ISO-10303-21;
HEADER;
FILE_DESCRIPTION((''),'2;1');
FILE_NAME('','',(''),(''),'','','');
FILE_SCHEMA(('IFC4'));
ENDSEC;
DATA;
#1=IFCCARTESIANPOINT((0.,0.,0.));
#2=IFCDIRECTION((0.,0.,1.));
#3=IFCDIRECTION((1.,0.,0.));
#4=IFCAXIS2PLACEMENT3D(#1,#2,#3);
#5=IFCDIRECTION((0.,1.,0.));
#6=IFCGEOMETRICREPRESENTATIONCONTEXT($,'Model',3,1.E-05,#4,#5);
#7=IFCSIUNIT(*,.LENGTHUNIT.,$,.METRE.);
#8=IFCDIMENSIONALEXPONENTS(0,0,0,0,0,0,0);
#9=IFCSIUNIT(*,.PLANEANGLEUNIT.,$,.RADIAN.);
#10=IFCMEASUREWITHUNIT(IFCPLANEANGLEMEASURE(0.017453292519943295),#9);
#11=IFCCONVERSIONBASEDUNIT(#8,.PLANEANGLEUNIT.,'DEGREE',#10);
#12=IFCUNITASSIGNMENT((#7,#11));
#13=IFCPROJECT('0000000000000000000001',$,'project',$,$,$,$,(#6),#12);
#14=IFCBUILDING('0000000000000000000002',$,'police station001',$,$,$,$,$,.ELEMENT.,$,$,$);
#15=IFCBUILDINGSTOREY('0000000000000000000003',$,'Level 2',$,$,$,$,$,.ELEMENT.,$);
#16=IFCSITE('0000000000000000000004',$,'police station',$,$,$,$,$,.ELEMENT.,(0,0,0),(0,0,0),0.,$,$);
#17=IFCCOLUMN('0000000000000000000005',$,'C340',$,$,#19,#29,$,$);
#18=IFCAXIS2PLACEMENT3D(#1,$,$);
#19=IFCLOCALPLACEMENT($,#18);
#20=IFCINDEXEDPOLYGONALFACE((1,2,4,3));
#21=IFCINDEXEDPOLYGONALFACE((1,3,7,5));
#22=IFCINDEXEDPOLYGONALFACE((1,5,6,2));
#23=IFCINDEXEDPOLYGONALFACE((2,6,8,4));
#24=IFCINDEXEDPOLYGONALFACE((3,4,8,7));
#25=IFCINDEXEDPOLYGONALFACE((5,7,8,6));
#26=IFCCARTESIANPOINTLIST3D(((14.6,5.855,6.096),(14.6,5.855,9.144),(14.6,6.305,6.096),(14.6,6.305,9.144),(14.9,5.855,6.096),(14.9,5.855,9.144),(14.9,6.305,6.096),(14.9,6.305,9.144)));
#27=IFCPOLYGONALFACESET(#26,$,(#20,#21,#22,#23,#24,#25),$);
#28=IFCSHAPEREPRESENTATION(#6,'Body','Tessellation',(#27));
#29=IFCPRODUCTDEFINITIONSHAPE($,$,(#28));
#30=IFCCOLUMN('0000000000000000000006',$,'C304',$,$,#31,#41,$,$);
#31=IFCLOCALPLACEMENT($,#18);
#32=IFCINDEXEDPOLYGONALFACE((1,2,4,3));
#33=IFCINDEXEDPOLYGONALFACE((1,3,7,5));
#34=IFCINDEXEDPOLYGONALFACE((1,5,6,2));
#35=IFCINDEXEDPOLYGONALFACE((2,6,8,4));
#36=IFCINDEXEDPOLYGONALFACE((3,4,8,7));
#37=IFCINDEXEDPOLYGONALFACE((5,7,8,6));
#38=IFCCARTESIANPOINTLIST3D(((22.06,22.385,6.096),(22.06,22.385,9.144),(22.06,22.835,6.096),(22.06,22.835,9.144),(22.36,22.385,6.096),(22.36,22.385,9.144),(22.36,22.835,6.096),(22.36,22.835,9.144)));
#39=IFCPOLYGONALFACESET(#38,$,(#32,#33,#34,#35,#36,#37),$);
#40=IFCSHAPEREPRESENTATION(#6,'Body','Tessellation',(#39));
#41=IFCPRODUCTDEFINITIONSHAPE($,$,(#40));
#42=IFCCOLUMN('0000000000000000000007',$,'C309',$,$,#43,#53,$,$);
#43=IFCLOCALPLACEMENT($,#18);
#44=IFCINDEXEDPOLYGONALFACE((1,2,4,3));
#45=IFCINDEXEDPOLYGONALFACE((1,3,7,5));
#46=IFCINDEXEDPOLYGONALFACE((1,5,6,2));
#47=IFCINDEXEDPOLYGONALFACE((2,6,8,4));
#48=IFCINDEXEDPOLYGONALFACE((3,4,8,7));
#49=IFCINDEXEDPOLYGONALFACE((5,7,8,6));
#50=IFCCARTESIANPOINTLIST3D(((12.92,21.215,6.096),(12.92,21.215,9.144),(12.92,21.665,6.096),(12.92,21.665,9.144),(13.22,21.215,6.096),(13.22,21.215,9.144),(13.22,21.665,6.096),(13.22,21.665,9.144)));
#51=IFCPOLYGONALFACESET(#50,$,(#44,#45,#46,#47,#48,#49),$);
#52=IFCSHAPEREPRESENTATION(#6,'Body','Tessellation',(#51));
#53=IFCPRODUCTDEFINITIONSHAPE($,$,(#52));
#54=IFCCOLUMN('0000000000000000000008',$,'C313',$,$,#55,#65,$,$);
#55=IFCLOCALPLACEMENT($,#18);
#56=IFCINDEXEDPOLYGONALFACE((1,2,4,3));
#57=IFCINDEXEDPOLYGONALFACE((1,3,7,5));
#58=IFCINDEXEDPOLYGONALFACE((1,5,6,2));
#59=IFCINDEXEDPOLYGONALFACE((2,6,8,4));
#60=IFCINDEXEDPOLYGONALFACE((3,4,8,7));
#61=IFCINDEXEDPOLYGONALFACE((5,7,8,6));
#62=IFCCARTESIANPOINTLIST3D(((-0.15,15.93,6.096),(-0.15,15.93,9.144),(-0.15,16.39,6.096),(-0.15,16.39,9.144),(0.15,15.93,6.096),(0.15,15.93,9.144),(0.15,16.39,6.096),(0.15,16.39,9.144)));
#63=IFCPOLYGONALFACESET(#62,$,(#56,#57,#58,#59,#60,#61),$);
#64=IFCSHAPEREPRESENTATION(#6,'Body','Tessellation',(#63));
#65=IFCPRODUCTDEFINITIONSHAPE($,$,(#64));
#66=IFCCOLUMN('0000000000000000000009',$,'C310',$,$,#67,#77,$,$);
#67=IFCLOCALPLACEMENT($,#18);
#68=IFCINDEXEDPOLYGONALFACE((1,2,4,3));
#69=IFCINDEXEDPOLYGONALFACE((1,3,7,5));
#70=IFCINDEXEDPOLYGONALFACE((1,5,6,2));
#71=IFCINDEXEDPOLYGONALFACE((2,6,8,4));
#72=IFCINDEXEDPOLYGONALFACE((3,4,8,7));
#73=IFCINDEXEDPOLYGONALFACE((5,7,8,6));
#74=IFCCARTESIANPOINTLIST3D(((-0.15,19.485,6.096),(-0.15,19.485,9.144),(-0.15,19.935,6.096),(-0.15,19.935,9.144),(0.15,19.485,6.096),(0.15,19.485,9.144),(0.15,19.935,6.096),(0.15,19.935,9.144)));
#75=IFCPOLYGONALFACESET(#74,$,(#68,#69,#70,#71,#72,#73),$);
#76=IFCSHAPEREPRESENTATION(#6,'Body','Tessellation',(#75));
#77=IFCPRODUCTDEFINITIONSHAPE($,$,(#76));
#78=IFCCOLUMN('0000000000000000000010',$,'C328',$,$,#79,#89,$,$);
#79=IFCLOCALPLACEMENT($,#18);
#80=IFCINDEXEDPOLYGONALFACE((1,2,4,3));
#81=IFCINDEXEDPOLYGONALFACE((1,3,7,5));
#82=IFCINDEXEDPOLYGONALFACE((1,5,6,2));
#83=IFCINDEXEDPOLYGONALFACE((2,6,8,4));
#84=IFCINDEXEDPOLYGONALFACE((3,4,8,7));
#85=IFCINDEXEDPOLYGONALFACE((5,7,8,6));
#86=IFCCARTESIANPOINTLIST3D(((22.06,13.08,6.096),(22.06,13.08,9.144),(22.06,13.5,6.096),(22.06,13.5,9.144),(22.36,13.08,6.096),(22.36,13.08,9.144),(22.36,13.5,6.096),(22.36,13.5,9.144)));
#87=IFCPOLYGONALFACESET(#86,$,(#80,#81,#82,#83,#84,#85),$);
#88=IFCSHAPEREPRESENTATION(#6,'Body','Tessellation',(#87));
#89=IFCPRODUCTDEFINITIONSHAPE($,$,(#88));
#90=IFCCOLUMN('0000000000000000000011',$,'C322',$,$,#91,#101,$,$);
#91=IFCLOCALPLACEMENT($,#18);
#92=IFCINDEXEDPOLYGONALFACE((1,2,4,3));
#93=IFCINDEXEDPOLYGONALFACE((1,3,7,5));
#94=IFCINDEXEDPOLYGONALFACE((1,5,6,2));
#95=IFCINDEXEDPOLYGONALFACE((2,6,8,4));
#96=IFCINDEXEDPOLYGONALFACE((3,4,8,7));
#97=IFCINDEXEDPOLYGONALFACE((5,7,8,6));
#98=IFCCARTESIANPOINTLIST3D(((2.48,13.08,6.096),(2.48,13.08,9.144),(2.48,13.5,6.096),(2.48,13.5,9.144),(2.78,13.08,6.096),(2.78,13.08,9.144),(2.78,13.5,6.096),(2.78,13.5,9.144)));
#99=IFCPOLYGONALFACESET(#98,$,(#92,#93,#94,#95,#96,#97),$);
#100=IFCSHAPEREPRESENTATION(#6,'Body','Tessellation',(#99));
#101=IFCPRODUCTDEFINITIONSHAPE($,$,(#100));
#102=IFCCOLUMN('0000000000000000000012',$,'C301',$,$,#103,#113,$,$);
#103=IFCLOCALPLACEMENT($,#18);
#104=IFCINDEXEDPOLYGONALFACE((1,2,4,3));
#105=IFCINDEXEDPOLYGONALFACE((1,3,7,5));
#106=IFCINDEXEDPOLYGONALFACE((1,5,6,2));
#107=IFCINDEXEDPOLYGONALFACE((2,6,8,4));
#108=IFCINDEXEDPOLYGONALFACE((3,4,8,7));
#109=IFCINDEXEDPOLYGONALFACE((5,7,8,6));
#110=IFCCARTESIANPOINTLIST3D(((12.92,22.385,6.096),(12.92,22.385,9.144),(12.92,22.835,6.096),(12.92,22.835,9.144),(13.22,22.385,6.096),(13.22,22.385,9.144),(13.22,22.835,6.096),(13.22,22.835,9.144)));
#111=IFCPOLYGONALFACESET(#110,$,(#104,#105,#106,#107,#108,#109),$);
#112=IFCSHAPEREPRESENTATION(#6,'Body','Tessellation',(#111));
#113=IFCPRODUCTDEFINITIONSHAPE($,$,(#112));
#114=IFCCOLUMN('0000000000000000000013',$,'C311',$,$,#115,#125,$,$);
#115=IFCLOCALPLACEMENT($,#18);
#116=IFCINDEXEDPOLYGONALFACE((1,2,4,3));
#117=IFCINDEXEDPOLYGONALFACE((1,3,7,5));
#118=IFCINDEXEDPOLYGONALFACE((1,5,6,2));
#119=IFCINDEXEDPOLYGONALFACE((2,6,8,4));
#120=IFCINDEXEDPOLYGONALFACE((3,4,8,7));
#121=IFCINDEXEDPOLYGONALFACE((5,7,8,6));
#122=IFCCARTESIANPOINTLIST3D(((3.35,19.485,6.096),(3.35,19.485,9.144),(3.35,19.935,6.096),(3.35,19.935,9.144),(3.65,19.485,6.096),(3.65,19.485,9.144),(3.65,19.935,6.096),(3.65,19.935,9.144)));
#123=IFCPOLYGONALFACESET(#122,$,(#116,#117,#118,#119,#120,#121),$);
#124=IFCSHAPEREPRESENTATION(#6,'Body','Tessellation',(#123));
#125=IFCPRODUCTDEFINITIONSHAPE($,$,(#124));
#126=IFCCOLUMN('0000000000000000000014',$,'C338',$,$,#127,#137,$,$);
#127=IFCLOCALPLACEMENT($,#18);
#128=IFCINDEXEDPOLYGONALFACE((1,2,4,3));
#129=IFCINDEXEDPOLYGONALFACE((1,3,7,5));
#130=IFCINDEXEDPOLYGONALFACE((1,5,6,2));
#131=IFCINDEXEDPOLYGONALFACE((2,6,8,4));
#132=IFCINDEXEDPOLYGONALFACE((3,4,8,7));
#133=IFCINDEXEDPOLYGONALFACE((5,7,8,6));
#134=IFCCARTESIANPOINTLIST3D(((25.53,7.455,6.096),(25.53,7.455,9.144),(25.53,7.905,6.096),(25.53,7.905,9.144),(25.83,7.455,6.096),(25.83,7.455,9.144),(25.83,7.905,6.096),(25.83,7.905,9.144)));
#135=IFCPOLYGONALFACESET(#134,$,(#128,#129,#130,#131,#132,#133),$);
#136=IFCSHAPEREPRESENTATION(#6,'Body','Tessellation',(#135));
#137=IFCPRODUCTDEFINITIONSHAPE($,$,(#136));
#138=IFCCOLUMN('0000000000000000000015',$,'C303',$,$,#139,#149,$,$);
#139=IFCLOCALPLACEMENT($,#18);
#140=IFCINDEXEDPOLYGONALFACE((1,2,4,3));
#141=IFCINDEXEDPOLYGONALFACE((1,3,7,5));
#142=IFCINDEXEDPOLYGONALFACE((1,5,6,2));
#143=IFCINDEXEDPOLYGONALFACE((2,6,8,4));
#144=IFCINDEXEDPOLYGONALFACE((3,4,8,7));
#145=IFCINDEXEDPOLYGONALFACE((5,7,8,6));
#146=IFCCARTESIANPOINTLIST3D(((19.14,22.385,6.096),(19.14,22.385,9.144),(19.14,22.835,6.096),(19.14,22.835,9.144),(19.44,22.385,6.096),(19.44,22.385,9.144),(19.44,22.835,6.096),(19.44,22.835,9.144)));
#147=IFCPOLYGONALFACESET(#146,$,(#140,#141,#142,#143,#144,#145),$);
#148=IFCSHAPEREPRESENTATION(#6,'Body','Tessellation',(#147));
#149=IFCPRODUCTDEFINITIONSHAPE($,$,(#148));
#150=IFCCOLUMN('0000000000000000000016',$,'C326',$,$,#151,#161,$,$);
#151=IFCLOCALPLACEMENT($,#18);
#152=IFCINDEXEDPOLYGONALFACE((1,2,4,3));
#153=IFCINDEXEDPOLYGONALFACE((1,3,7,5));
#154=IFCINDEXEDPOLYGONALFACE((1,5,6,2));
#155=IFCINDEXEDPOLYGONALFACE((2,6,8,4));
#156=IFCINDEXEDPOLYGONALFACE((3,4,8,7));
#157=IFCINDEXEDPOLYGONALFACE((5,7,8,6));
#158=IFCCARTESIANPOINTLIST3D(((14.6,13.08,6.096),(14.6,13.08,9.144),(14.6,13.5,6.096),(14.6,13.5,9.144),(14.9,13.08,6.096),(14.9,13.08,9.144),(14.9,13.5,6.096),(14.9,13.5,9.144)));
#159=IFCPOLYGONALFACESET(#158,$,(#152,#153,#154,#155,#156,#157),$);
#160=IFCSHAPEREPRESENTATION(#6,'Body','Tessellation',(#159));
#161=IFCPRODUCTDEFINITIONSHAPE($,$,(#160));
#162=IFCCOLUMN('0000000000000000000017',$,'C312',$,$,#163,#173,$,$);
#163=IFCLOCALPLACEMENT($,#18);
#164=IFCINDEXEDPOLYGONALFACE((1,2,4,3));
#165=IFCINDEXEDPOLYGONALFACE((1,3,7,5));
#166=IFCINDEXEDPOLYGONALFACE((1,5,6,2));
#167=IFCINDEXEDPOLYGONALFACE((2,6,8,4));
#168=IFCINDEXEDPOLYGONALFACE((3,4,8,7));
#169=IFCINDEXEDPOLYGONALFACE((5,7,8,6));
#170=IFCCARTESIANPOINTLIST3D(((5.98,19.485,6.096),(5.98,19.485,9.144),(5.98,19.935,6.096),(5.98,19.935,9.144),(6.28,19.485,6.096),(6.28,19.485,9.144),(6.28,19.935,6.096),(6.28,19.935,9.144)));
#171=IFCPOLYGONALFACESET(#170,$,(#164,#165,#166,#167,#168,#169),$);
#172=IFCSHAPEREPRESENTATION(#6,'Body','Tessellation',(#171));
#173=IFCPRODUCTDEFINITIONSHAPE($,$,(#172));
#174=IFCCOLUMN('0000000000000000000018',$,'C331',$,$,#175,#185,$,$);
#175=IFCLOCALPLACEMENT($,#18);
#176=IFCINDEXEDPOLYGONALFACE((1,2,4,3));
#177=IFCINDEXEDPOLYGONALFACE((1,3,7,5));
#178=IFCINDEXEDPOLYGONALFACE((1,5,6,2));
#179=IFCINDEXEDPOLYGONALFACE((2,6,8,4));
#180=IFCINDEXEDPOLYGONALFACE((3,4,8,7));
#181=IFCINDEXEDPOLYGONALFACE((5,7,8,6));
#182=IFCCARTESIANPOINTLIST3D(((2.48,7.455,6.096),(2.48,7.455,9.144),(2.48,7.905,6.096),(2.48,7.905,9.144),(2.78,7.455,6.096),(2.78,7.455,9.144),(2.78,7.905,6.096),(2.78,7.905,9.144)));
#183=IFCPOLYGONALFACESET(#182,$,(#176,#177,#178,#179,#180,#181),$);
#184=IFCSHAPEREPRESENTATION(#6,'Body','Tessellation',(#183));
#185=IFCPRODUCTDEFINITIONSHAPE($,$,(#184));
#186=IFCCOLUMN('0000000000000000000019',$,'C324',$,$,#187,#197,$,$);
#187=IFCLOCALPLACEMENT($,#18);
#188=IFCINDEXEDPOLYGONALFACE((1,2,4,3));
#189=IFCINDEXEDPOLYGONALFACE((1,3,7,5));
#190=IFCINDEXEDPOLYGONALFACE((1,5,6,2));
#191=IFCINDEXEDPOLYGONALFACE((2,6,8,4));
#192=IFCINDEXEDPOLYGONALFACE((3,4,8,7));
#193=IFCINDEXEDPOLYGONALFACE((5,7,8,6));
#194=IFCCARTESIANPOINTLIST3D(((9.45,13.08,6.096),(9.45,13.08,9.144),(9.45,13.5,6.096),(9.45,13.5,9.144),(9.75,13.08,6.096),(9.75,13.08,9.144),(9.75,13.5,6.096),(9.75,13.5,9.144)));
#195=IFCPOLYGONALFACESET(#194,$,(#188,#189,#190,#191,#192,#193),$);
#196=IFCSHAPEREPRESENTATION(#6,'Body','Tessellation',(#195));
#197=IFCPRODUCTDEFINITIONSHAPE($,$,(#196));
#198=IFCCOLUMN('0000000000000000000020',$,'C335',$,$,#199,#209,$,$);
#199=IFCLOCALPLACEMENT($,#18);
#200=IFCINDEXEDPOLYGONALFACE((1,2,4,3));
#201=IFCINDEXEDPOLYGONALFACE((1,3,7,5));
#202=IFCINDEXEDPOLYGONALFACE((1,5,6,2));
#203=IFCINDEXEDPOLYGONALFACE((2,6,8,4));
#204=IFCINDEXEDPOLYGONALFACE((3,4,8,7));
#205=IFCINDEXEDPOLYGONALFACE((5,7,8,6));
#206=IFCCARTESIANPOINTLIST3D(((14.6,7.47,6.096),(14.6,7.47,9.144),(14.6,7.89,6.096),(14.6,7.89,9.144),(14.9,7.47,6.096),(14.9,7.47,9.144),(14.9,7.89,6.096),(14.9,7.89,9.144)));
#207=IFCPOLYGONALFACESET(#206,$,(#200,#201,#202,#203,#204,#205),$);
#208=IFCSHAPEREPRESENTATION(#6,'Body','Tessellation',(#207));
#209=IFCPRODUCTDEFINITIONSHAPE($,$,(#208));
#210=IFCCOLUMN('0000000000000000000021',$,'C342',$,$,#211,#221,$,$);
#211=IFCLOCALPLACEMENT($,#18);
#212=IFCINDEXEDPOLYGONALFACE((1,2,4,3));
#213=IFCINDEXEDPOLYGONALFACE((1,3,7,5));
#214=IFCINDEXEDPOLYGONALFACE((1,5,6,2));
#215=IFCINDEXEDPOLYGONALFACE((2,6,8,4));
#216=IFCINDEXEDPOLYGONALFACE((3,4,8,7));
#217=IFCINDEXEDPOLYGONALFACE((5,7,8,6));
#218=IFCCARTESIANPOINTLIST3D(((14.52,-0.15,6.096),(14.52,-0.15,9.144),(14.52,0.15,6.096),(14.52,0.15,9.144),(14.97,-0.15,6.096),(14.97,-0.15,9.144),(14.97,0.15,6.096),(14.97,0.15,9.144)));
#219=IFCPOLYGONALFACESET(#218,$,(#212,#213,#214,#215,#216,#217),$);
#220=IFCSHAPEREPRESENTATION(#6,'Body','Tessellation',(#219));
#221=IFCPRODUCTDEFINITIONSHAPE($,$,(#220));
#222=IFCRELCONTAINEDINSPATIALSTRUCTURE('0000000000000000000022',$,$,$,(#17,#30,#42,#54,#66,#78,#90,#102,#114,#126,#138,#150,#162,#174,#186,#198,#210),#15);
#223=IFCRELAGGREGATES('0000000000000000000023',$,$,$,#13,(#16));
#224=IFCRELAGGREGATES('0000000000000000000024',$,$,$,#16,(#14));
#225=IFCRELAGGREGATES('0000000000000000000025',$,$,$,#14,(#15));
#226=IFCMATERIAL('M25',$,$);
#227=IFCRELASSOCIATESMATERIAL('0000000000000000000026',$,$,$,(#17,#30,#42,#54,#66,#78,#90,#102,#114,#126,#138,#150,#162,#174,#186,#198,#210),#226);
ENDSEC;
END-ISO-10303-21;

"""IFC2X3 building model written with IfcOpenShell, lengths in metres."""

from ifc_helpers import new_model, entity, si_unit, converted_unit, direction, frame, frame_2d, origin_with_axes, place, context, project, spatial, rectangle, extrude, material, element, save


model = new_model("IFC2X3")

# Units and contexts
model_context = context("Model", 3, precision=1e-05, world=origin_with_axes(), true_north=direction((0.0, 1.0, 0.0)))
ifc_project = project(units=[si_unit("LENGTHUNIT", "METRE"), converted_unit("PLANEANGLEUNIT", "DEGREE", entity("IfcPlaneAngleMeasure", 0.017453292519943295), si_unit("PLANEANGLEUNIT", "RADIAN"), dimensions=[0, 0, 0, 0, 0, 0, 0])], contexts=[model_context])

# Site, building, storey
site = spatial("IfcSite", under=ifc_project, Name="police station", CompositionType="ELEMENT", RefLatitude=(0, 0, 0), RefLongitude=(0, 0, 0), RefElevation=0.0)
building = spatial("IfcBuilding", under=site, Name="police station001", CompositionType="ELEMENT")
storey = spatial("IfcBuildingStorey", under=building, Name="Level 2", CompositionType="ELEMENT")

# Columns
ifc_material = material(Name="M25")
placement = place(None, origin_with_axes())
element("IfcColumn", 1, at=placement, inside=storey, material=ifc_material, Name="C340", context=model_context, shape_type="SweptSolid", body=[
    extrude(rectangle(XDim=0.3, YDim=0.45, at=frame_2d((0.0, 0.0), x_axis=(1.0, 0.0, 0.0))), frame((14.75, 6.08, 6.096), z_axis=(0.0, 0.0, 1.0), x_axis=(1.0, 0.0, 0.0)), (0.0, 0.0, 1.0), 3.048),
])
element("IfcColumn", 2, at=placement, inside=storey, material=ifc_material, Name="C304", context=model_context, shape_type="SweptSolid", body=[
    extrude(rectangle(XDim=0.3, YDim=0.45, at=frame_2d((0.0, 0.0), x_axis=(1.0, 0.0, 0.0))), frame((22.21, 22.61, 6.096), z_axis=(0.0, 0.0, 1.0), x_axis=(1.0, 0.0, 0.0)), (0.0, 0.0, 1.0), 3.048),
])
element("IfcColumn", 3, at=placement, inside=storey, material=ifc_material, Name="C309", context=model_context, shape_type="SweptSolid", body=[
    extrude(rectangle(XDim=0.3, YDim=0.45, at=frame_2d((0.0, 0.0), x_axis=(1.0, 0.0, 0.0))), frame((13.07, 21.44, 6.096), z_axis=(0.0, 0.0, 1.0), x_axis=(1.0, 0.0, 0.0)), (0.0, 0.0, 1.0), 3.048),
])
element("IfcColumn", 4, at=placement, inside=storey, material=ifc_material, Name="C313", context=model_context, shape_type="SweptSolid", body=[
    extrude(rectangle(XDim=0.3, YDim=0.46, at=frame_2d((0.0, 0.0), x_axis=(1.0, 0.0, 0.0))), frame((0.0, 16.16, 6.096), z_axis=(0.0, 0.0, 1.0), x_axis=(1.0, 0.0, 0.0)), (0.0, 0.0, 1.0), 3.048),
])
element("IfcColumn", 5, at=placement, inside=storey, material=ifc_material, Name="C310", context=model_context, shape_type="SweptSolid", body=[
    extrude(rectangle(XDim=0.3, YDim=0.45, at=frame_2d((0.0, 0.0), x_axis=(1.0, 0.0, 0.0))), frame((0.0, 19.71, 6.096), z_axis=(0.0, 0.0, 1.0), x_axis=(1.0, 0.0, 0.0)), (0.0, 0.0, 1.0), 3.048),
])
element("IfcColumn", 6, at=placement, inside=storey, material=ifc_material, Name="C328", context=model_context, shape_type="SweptSolid", body=[
    extrude(rectangle(XDim=0.3, YDim=0.42, at=frame_2d((0.0, 0.0), x_axis=(1.0, 0.0, 0.0))), frame((22.21, 13.29, 6.096), z_axis=(0.0, 0.0, 1.0), x_axis=(1.0, 0.0, 0.0)), (0.0, 0.0, 1.0), 3.048),
])
element("IfcColumn", 7, at=placement, inside=storey, material=ifc_material, Name="C322", context=model_context, shape_type="SweptSolid", body=[
    extrude(rectangle(XDim=0.3, YDim=0.42, at=frame_2d((0.0, 0.0), x_axis=(1.0, 0.0, 0.0))), frame((2.63, 13.29, 6.096), z_axis=(0.0, 0.0, 1.0), x_axis=(1.0, 0.0, 0.0)), (0.0, 0.0, 1.0), 3.048),
])
element("IfcColumn", 8, at=placement, inside=storey, material=ifc_material, Name="C301", context=model_context, shape_type="SweptSolid", body=[
    extrude(rectangle(XDim=0.3, YDim=0.45, at=frame_2d((0.0, 0.0), x_axis=(1.0, 0.0, 0.0))), frame((13.07, 22.61, 6.096), z_axis=(0.0, 0.0, 1.0), x_axis=(1.0, 0.0, 0.0)), (0.0, 0.0, 1.0), 3.048),
])
element("IfcColumn", 9, at=placement, inside=storey, material=ifc_material, Name="C311", context=model_context, shape_type="SweptSolid", body=[
    extrude(rectangle(XDim=0.3, YDim=0.45, at=frame_2d((0.0, 0.0), x_axis=(1.0, 0.0, 0.0))), frame((3.5, 19.71, 6.096), z_axis=(0.0, 0.0, 1.0), x_axis=(1.0, 0.0, 0.0)), (0.0, 0.0, 1.0), 3.048),
])
element("IfcColumn", 10, at=placement, inside=storey, material=ifc_material, Name="C338", context=model_context, shape_type="SweptSolid", body=[
    extrude(rectangle(XDim=0.3, YDim=0.45, at=frame_2d((0.0, 0.0), x_axis=(1.0, 0.0, 0.0))), frame((25.68, 7.68, 6.096), z_axis=(0.0, 0.0, 1.0), x_axis=(1.0, 0.0, 0.0)), (0.0, 0.0, 1.0), 3.048),
])
element("IfcColumn", 11, at=placement, inside=storey, material=ifc_material, Name="C303", context=model_context, shape_type="SweptSolid", body=[
    extrude(rectangle(XDim=0.3, YDim=0.45, at=frame_2d((0.0, 0.0), x_axis=(1.0, 0.0, 0.0))), frame((19.29, 22.61, 6.096), z_axis=(0.0, 0.0, 1.0), x_axis=(1.0, 0.0, 0.0)), (0.0, 0.0, 1.0), 3.048),
])
element("IfcColumn", 12, at=placement, inside=storey, material=ifc_material, Name="C326", context=model_context, shape_type="SweptSolid", body=[
    extrude(rectangle(XDim=0.3, YDim=0.42, at=frame_2d((0.0, 0.0), x_axis=(1.0, 0.0, 0.0))), frame((14.75, 13.29, 6.096), z_axis=(0.0, 0.0, 1.0), x_axis=(1.0, 0.0, 0.0)), (0.0, 0.0, 1.0), 3.048),
])
element("IfcColumn", 13, at=placement, inside=storey, material=ifc_material, Name="C312", context=model_context, shape_type="SweptSolid", body=[
    extrude(rectangle(XDim=0.3, YDim=0.45, at=frame_2d((0.0, 0.0), x_axis=(1.0, 0.0, 0.0))), frame((6.13, 19.71, 6.096), z_axis=(0.0, 0.0, 1.0), x_axis=(1.0, 0.0, 0.0)), (0.0, 0.0, 1.0), 3.048),
])
element("IfcColumn", 14, at=placement, inside=storey, material=ifc_material, Name="C331", context=model_context, shape_type="SweptSolid", body=[
    extrude(rectangle(XDim=0.3, YDim=0.45, at=frame_2d((0.0, 0.0), x_axis=(1.0, 0.0, 0.0))), frame((2.63, 7.68, 6.096), z_axis=(0.0, 0.0, 1.0), x_axis=(1.0, 0.0, 0.0)), (0.0, 0.0, 1.0), 3.048),
])
element("IfcColumn", 15, at=placement, inside=storey, material=ifc_material, Name="C324", context=model_context, shape_type="SweptSolid", body=[
    extrude(rectangle(XDim=0.3, YDim=0.42, at=frame_2d((0.0, 0.0), x_axis=(1.0, 0.0, 0.0))), frame((9.6, 13.29, 6.096), z_axis=(0.0, 0.0, 1.0), x_axis=(1.0, 0.0, 0.0)), (0.0, 0.0, 1.0), 3.048),
])
element("IfcColumn", 16, at=placement, inside=storey, material=ifc_material, Name="C335", context=model_context, shape_type="SweptSolid", body=[
    extrude(rectangle(XDim=0.3, YDim=0.42, at=frame_2d((0.0, 0.0), x_axis=(1.0, 0.0, 0.0))), frame((14.75, 7.68, 6.096), z_axis=(0.0, 0.0, 1.0), x_axis=(1.0, 0.0, 0.0)), (0.0, 0.0, 1.0), 3.048),
])
element("IfcColumn", 17, at=placement, inside=storey, material=ifc_material, Name="C342", context=model_context, shape_type="SweptSolid", body=[
    extrude(rectangle(XDim=0.45, YDim=0.3, at=frame_2d((0.0, 0.0), x_axis=(1.0, 0.0, 0.0))), frame((14.745, 0.0, 6.096), z_axis=(0.0, 0.0, 1.0), x_axis=(1.0, 0.0, 0.0)), (0.0, 0.0, 1.0), 3.048),
])

save(model, "model.ifc")
